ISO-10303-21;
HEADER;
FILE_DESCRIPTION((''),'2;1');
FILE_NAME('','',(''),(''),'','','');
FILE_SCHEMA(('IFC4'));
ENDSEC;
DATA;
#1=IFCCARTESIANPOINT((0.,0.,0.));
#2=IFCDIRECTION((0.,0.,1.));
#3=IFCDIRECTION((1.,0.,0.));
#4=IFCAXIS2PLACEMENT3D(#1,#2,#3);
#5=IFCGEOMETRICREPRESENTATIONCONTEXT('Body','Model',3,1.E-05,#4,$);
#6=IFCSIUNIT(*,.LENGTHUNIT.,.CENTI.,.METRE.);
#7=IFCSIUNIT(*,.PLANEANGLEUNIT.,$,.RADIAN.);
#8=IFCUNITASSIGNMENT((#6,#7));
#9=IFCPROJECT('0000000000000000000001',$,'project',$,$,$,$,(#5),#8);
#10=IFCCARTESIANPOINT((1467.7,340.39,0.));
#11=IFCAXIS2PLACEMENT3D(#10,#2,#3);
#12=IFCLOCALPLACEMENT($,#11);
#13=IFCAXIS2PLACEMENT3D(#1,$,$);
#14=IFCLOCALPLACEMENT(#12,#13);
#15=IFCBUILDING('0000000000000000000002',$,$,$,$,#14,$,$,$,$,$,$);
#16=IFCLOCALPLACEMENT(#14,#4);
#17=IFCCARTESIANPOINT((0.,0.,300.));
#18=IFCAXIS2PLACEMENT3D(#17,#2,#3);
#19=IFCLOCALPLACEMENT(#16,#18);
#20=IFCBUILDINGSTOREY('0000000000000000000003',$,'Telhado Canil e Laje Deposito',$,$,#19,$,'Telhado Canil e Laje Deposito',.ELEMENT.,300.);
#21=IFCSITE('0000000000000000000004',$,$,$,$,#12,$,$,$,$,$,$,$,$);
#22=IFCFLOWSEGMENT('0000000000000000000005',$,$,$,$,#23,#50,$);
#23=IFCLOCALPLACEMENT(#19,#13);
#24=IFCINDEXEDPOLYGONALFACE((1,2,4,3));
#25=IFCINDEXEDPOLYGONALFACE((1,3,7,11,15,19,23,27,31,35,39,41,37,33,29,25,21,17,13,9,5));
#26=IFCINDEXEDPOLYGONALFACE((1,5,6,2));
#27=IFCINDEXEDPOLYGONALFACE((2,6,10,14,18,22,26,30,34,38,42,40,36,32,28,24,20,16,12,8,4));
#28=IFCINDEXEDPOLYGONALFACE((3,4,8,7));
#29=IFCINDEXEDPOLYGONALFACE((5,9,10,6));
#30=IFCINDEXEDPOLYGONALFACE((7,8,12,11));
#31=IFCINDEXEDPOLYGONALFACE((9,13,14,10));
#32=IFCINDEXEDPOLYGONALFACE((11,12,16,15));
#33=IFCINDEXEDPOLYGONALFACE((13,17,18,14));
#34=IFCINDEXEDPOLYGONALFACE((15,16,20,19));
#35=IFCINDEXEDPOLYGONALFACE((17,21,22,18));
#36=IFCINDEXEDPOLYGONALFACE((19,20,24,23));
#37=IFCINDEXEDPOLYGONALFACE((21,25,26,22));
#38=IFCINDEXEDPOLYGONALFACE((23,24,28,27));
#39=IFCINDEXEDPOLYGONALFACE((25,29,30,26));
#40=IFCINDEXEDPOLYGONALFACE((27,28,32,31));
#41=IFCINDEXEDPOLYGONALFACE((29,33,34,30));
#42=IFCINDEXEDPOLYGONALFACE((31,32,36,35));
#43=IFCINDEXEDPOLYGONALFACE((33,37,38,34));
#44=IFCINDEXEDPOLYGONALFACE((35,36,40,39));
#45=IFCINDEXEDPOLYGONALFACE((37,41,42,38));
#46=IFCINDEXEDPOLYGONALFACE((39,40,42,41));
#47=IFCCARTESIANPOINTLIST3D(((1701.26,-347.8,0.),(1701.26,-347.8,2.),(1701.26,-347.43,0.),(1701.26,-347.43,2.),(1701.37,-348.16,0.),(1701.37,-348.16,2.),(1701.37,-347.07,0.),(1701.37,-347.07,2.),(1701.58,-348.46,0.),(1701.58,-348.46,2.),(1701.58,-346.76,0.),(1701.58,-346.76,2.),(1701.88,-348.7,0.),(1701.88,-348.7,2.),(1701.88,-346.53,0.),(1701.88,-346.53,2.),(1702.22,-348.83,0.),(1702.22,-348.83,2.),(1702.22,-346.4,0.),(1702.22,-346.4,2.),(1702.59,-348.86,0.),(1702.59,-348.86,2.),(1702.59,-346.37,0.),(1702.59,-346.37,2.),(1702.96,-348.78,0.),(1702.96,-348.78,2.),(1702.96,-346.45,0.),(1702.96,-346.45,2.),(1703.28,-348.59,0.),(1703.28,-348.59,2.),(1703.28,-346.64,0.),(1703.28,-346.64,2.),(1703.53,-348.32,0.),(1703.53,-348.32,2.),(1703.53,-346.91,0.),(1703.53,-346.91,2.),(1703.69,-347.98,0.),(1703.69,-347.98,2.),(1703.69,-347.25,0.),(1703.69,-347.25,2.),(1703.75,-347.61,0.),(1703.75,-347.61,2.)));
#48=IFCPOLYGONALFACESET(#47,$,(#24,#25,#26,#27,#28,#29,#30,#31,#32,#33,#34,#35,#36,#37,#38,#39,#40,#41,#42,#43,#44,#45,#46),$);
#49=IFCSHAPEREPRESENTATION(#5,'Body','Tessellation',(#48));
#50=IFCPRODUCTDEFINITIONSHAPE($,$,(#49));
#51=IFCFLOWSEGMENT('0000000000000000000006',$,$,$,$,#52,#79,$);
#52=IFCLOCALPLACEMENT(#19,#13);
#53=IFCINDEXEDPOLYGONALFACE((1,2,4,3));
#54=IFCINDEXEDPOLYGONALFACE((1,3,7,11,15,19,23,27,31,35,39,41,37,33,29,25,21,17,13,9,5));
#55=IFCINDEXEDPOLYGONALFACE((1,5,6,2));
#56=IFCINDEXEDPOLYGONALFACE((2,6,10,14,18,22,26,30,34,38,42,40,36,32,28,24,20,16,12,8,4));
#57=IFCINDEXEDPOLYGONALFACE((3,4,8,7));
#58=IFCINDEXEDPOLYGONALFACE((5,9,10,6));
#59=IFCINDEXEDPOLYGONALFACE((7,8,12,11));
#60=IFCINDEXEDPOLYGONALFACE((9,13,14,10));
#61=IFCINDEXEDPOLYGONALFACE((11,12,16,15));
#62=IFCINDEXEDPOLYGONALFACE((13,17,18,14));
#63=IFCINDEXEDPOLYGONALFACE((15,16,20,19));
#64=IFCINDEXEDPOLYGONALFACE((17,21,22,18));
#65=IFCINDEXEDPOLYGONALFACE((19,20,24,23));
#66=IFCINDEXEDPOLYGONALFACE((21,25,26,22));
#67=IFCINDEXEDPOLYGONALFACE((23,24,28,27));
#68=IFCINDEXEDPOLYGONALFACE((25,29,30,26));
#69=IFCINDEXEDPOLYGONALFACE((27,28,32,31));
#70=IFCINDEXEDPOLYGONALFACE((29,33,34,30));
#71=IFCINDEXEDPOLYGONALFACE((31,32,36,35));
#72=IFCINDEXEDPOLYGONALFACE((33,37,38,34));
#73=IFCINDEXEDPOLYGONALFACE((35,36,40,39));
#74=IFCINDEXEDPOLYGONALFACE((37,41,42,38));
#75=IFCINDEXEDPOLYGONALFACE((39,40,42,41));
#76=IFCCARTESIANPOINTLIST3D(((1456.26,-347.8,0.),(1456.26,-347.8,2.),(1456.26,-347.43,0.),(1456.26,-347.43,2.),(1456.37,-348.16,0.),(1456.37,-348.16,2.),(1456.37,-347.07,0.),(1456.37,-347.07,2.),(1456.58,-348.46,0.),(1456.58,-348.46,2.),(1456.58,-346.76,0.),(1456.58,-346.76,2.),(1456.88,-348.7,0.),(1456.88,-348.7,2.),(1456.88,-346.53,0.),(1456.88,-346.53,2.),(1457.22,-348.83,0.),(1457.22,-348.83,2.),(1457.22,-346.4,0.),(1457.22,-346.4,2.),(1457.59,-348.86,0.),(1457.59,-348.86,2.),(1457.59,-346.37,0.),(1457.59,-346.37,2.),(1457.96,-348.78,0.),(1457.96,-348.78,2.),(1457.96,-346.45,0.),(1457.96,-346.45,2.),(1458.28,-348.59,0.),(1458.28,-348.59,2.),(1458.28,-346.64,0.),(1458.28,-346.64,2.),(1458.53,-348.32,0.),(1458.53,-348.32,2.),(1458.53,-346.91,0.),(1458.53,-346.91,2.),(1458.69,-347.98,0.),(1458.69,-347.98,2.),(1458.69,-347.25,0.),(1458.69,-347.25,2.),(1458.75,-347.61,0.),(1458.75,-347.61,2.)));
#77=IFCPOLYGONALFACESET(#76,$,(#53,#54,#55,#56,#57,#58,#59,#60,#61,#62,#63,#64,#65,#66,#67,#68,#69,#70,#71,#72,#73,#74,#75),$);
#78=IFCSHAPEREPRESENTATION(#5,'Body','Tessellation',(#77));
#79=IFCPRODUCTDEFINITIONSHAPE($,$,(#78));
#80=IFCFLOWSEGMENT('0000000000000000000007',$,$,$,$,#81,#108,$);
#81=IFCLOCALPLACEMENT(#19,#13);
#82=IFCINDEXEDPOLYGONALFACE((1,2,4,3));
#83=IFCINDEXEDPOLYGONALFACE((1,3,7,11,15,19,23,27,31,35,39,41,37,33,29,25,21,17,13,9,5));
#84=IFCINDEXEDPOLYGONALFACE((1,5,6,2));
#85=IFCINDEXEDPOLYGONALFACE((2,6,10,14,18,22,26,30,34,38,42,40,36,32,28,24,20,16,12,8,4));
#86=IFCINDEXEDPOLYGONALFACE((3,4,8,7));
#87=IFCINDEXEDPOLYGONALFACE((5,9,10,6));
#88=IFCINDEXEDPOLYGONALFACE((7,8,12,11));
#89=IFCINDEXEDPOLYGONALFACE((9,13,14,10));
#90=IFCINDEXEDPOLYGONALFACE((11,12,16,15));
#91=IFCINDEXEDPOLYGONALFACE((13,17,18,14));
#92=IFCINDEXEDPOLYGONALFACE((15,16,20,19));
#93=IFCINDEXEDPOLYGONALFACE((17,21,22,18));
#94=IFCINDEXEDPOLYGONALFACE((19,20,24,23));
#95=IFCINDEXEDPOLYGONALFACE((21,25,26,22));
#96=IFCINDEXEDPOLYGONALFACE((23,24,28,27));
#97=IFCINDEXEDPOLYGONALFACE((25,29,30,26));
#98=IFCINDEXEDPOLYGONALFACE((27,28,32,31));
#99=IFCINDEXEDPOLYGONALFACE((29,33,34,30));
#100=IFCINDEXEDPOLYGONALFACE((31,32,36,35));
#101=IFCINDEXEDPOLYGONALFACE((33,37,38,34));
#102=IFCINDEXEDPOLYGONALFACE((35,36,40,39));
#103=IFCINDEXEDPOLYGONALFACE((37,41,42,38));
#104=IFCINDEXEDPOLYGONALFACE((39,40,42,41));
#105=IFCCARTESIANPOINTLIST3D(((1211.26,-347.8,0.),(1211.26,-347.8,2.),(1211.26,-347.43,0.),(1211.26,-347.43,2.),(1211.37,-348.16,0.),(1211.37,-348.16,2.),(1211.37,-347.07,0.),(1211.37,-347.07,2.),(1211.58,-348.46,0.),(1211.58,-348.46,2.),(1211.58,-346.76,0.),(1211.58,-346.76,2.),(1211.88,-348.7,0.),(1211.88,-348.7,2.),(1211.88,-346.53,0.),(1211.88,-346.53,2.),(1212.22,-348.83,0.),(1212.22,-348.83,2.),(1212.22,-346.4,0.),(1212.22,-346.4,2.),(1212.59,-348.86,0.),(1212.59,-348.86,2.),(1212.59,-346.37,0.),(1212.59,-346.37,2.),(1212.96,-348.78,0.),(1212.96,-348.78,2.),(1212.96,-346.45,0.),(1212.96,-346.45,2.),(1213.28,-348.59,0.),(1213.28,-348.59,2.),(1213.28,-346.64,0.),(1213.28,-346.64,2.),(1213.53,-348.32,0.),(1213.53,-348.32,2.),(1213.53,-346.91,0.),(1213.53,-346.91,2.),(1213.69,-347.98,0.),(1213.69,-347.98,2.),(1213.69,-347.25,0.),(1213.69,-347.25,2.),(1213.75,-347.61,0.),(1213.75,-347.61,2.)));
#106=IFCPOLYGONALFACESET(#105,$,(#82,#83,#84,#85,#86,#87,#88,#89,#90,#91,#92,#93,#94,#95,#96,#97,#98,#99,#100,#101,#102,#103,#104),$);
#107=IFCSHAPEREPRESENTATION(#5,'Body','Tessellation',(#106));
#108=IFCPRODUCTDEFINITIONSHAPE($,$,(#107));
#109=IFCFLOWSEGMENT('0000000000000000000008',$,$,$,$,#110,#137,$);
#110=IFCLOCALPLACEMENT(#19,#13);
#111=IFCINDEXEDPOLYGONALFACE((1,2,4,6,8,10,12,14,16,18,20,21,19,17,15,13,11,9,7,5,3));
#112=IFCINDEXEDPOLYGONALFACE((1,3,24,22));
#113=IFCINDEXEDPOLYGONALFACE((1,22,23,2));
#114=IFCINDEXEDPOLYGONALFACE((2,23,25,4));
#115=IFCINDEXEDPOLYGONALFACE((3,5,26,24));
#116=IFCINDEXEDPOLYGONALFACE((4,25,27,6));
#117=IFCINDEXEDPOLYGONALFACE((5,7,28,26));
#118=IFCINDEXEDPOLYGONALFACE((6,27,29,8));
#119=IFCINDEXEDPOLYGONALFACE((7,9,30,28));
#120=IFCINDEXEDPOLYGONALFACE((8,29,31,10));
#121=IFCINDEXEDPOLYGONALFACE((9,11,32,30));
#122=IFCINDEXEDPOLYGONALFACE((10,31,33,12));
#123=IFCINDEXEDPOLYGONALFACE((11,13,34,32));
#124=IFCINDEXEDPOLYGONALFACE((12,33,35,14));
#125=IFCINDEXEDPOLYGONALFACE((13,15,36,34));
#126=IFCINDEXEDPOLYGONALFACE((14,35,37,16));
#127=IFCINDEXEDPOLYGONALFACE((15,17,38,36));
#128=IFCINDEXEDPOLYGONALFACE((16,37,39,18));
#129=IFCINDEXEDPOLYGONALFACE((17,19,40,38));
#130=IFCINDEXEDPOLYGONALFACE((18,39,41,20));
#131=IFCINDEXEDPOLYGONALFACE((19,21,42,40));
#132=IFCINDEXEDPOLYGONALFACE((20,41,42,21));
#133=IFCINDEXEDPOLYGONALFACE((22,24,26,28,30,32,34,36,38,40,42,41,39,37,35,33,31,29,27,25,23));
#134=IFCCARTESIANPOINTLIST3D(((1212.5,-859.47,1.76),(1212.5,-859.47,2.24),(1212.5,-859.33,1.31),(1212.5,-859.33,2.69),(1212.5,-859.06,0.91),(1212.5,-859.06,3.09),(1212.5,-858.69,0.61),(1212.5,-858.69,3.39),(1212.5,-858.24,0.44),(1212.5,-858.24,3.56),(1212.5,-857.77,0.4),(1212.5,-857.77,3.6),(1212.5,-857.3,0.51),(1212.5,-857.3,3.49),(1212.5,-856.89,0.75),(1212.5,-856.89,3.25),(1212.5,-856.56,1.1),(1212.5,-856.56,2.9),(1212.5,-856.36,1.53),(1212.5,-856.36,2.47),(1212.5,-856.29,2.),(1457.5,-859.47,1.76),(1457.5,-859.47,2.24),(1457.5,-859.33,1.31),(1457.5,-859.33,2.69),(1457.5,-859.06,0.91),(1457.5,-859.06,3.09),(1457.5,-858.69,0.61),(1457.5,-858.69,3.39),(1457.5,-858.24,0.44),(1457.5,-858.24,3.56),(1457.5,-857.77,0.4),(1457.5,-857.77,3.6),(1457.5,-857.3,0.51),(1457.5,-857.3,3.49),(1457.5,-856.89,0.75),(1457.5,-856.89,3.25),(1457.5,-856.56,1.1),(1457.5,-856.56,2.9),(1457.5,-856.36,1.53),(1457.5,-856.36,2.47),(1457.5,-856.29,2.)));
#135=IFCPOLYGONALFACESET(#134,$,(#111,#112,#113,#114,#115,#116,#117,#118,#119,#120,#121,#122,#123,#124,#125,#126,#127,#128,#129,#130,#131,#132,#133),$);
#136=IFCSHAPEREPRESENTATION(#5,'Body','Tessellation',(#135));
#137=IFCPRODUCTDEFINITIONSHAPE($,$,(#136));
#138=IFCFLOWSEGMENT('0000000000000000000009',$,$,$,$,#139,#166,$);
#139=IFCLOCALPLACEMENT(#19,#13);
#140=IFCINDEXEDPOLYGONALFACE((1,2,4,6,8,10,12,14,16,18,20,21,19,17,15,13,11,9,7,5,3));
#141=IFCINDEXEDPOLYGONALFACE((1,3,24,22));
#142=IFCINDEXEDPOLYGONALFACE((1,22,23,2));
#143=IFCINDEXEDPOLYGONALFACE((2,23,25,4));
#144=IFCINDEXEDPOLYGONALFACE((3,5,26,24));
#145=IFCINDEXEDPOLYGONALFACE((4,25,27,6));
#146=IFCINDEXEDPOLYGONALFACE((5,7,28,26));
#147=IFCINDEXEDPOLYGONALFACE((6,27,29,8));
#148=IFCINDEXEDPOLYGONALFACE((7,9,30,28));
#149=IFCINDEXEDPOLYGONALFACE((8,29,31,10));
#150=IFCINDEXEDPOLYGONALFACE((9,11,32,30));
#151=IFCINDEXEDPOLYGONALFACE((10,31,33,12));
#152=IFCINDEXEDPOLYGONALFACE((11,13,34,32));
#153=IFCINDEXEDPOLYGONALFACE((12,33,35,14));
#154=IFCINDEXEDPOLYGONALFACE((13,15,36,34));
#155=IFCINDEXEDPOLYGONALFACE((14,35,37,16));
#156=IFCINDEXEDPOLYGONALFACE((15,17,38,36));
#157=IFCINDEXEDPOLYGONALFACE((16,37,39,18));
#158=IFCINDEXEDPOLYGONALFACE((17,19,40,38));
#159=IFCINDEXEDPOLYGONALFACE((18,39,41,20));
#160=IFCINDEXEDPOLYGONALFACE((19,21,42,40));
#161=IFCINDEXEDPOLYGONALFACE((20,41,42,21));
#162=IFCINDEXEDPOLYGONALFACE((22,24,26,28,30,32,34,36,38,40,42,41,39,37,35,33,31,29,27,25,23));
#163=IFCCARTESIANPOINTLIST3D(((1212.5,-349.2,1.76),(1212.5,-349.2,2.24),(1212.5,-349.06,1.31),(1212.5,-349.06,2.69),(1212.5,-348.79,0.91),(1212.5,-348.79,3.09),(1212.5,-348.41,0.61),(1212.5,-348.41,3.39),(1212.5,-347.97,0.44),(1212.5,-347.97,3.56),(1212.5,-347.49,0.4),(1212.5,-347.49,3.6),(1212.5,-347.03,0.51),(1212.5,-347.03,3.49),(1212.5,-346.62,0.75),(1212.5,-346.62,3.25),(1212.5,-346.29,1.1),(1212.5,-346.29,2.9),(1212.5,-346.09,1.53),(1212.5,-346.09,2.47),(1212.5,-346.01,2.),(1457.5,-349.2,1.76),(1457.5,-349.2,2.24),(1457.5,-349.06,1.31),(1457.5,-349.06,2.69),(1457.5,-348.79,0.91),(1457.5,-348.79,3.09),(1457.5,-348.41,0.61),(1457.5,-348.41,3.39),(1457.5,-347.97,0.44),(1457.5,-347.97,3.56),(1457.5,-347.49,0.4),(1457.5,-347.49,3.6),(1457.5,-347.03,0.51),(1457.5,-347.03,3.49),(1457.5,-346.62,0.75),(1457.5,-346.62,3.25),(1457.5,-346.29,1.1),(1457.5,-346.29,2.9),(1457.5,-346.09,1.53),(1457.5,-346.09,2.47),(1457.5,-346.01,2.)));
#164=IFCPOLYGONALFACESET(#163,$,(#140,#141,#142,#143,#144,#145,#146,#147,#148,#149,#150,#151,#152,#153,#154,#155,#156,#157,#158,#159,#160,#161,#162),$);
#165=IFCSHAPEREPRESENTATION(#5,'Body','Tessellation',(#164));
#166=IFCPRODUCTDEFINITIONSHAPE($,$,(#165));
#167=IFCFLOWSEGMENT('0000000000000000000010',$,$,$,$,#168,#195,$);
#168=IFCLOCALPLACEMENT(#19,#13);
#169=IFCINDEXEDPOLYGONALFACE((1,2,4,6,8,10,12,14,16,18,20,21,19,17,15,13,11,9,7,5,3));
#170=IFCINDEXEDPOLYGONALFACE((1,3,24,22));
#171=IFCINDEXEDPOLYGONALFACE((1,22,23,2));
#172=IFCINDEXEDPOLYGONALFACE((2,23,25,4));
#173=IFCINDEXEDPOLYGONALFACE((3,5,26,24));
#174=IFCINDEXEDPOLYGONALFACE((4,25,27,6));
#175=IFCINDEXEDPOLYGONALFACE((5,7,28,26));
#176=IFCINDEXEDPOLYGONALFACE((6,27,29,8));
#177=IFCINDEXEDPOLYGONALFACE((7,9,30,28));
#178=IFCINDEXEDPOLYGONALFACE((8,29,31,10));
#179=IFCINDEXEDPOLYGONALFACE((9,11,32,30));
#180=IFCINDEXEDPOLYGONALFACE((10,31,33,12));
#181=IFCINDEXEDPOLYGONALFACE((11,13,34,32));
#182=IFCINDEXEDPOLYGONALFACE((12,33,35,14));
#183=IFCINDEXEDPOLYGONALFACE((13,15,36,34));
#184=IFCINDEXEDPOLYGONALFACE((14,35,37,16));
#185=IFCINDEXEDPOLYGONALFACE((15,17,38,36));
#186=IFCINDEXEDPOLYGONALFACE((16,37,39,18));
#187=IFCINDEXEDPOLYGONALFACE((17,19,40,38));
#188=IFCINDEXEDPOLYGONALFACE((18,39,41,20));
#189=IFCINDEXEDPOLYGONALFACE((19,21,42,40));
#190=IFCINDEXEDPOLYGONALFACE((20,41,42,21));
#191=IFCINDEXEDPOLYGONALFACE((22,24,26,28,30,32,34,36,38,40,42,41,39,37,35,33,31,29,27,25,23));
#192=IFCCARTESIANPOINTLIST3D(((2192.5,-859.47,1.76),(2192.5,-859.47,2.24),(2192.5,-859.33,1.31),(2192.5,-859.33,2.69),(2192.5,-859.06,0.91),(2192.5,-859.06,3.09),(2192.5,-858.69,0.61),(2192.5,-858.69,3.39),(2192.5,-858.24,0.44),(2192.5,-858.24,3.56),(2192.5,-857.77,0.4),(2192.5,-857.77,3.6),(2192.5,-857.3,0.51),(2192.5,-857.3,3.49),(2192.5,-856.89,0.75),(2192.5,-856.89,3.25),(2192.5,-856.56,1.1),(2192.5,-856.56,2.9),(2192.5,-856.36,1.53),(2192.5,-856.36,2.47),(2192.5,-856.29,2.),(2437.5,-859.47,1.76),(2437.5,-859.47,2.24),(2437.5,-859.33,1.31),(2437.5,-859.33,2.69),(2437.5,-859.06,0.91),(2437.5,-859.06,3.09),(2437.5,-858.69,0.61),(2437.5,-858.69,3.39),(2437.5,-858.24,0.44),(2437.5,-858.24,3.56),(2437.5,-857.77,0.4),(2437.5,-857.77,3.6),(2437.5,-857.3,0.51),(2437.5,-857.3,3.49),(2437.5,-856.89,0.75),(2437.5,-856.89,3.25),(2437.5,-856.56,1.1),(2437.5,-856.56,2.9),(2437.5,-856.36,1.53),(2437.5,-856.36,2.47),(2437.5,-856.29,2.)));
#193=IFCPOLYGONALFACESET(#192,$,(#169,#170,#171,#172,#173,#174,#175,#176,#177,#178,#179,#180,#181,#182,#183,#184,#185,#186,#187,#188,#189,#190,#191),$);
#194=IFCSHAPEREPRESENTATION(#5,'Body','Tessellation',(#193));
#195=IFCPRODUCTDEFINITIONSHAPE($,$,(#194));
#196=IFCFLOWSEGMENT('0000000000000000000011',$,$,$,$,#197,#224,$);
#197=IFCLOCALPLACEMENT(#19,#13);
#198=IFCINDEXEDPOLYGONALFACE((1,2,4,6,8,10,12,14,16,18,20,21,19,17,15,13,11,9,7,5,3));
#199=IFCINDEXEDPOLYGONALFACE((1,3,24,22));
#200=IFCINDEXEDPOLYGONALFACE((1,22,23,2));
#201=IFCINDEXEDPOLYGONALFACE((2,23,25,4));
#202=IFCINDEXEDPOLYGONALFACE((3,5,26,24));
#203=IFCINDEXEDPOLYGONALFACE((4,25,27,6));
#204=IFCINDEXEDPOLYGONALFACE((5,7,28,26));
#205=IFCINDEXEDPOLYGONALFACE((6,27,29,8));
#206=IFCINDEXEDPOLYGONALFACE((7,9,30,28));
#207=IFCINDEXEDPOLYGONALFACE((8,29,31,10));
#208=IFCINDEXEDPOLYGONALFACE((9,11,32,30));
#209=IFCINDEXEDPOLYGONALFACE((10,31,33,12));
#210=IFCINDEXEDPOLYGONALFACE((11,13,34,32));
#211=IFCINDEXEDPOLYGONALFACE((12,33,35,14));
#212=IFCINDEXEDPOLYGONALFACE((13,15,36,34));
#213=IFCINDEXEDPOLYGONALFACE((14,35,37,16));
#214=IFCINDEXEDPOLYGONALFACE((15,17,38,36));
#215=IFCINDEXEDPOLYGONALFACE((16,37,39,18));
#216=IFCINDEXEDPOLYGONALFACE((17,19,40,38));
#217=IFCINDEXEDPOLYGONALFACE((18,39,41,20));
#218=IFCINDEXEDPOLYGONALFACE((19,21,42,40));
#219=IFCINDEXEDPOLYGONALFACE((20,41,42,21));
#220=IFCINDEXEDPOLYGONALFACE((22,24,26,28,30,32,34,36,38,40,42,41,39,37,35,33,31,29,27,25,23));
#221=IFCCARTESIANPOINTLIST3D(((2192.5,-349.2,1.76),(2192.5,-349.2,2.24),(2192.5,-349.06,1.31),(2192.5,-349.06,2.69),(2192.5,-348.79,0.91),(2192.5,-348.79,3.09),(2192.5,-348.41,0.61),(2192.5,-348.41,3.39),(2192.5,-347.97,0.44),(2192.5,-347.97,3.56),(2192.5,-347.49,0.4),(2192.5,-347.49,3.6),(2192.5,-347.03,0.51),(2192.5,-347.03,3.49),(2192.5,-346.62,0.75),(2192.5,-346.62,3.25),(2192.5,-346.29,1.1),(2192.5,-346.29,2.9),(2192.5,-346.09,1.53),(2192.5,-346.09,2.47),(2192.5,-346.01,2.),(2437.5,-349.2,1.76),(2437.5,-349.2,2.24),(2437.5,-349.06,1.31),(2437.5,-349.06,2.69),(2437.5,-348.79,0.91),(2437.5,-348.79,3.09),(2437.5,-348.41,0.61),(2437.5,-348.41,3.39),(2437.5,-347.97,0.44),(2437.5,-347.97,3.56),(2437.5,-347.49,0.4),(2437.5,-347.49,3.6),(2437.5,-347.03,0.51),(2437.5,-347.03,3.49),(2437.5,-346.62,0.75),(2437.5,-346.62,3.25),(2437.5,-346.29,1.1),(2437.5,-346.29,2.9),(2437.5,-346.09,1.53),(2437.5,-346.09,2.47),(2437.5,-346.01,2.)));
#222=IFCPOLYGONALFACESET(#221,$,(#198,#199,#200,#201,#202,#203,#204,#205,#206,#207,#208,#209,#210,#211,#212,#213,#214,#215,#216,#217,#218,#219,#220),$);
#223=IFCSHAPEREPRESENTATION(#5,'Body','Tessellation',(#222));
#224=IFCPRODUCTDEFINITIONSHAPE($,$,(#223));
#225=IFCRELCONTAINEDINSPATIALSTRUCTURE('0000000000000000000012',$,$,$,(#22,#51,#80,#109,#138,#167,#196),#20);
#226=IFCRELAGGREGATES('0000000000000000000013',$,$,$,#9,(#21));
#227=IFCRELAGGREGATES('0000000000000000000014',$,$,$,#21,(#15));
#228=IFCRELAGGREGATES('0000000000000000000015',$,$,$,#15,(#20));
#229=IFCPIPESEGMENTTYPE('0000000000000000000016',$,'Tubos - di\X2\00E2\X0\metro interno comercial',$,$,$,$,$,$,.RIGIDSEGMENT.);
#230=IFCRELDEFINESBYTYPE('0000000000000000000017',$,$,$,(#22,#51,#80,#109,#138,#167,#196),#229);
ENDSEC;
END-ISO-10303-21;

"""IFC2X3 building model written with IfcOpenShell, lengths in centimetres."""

from ifc_helpers import new_model, si_unit, frame, origin, origin_with_axes, origin_2d_with_axis, place, context, project, spatial, circle, extrude, type_object, element, save


model = new_model("IFC2X3")

# Units and contexts
model_context = context("Model", 3, precision=1e-05, world=origin_with_axes(), identifier="Body")
ifc_project = project(units=[si_unit("LENGTHUNIT", "METRE", prefix="CENTI"), si_unit("PLANEANGLEUNIT", "RADIAN")], contexts=[model_context])

# Site, building, storey
site_placement = place(None, frame((1467.7, 340.39, 0.0), z_axis=(0.0, 0.0, 1.0), x_axis=(1.0, 0.0, 0.0)))
site = spatial("IfcSite", under=ifc_project, at=site_placement)
building_placement = place(site_placement, origin())
building = spatial("IfcBuilding", under=site, at=building_placement)
placement = place(building_placement, origin_with_axes())
storey_placement = place(placement, frame((0.0, 0.0, 300.0), z_axis=(0.0, 0.0, 1.0), x_axis=(1.0, 0.0, 0.0)))
storey = spatial("IfcBuildingStorey", under=building, at=storey_placement, Name="Telhado Canil e Laje Deposito", LongName="Telhado Canil e Laje Deposito", CompositionType="ELEMENT", Elevation=300.0)

# Flow segments
pipe_segment_type = type_object("IfcPipeSegmentType", Name="Tubos - diâmetro interno comercial", PredefinedType="RIGIDSEGMENT")
for number, where, z_axis, x_axis in (
    (1, (1702.5, -347.61, 2.0), (0.0, 0.0, 1.0), (1.0, 0.0, 0.0)),
    (2, (1457.5, -347.61, 2.0), (0.0, 0.0, 1.0), (1.0, 0.0, 0.0)),
    (3, (1212.5, -347.61, 2.0), (0.0, 0.0, 1.0), (1.0, 0.0, 0.0)),
):
    element("IfcFlowSegment", number, at=place(storey_placement, frame(where, z_axis=z_axis, x_axis=x_axis)), inside=storey, type_object=pipe_segment_type, context=model_context, shape_type="SolidModel", body=[
        extrude(circle(Radius=1.25, at=origin_2d_with_axis()), frame((0.0, 0.0, 0.0), z_axis=(0.0, 0.0, -1.0), x_axis=(1.0, 0.0, 0.0)), (0.0, 0.0, 1.0), 2.0),
    ])
for number, where, z_axis, x_axis in (
    (4, (1335.0, -857.89, 3.6), (0.0, 0.0, 1.0), (1.0, 0.0, 0.0)),
    (5, (1335.0, -347.61, 3.6), (0.0, 0.0, 1.0), (1.0, 0.0, 0.0)),
    (6, (2315.0, -857.89, 3.6), (0.0, 0.0, 1.0), (1.0, 0.0, 0.0)),
    (7, (2315.0, -347.61, 3.6), (0.0, 0.0, 1.0), (1.0, 0.0, 0.0)),
):
    element("IfcFlowSegment", number, at=place(storey_placement, frame(where, z_axis=z_axis, x_axis=x_axis)), inside=storey, type_object=pipe_segment_type, context=model_context, shape_type="SolidModel", body=[
        extrude(circle(Radius=1.6, at=origin_2d_with_axis()), frame((122.5, 0.0, -1.6), z_axis=(-1.0, 0.0, 0.0), x_axis=(0.0, 1.0, 0.0)), (0.0, 0.0, 1.0), 245.0),
    ])

save(model, "model.ifc")
